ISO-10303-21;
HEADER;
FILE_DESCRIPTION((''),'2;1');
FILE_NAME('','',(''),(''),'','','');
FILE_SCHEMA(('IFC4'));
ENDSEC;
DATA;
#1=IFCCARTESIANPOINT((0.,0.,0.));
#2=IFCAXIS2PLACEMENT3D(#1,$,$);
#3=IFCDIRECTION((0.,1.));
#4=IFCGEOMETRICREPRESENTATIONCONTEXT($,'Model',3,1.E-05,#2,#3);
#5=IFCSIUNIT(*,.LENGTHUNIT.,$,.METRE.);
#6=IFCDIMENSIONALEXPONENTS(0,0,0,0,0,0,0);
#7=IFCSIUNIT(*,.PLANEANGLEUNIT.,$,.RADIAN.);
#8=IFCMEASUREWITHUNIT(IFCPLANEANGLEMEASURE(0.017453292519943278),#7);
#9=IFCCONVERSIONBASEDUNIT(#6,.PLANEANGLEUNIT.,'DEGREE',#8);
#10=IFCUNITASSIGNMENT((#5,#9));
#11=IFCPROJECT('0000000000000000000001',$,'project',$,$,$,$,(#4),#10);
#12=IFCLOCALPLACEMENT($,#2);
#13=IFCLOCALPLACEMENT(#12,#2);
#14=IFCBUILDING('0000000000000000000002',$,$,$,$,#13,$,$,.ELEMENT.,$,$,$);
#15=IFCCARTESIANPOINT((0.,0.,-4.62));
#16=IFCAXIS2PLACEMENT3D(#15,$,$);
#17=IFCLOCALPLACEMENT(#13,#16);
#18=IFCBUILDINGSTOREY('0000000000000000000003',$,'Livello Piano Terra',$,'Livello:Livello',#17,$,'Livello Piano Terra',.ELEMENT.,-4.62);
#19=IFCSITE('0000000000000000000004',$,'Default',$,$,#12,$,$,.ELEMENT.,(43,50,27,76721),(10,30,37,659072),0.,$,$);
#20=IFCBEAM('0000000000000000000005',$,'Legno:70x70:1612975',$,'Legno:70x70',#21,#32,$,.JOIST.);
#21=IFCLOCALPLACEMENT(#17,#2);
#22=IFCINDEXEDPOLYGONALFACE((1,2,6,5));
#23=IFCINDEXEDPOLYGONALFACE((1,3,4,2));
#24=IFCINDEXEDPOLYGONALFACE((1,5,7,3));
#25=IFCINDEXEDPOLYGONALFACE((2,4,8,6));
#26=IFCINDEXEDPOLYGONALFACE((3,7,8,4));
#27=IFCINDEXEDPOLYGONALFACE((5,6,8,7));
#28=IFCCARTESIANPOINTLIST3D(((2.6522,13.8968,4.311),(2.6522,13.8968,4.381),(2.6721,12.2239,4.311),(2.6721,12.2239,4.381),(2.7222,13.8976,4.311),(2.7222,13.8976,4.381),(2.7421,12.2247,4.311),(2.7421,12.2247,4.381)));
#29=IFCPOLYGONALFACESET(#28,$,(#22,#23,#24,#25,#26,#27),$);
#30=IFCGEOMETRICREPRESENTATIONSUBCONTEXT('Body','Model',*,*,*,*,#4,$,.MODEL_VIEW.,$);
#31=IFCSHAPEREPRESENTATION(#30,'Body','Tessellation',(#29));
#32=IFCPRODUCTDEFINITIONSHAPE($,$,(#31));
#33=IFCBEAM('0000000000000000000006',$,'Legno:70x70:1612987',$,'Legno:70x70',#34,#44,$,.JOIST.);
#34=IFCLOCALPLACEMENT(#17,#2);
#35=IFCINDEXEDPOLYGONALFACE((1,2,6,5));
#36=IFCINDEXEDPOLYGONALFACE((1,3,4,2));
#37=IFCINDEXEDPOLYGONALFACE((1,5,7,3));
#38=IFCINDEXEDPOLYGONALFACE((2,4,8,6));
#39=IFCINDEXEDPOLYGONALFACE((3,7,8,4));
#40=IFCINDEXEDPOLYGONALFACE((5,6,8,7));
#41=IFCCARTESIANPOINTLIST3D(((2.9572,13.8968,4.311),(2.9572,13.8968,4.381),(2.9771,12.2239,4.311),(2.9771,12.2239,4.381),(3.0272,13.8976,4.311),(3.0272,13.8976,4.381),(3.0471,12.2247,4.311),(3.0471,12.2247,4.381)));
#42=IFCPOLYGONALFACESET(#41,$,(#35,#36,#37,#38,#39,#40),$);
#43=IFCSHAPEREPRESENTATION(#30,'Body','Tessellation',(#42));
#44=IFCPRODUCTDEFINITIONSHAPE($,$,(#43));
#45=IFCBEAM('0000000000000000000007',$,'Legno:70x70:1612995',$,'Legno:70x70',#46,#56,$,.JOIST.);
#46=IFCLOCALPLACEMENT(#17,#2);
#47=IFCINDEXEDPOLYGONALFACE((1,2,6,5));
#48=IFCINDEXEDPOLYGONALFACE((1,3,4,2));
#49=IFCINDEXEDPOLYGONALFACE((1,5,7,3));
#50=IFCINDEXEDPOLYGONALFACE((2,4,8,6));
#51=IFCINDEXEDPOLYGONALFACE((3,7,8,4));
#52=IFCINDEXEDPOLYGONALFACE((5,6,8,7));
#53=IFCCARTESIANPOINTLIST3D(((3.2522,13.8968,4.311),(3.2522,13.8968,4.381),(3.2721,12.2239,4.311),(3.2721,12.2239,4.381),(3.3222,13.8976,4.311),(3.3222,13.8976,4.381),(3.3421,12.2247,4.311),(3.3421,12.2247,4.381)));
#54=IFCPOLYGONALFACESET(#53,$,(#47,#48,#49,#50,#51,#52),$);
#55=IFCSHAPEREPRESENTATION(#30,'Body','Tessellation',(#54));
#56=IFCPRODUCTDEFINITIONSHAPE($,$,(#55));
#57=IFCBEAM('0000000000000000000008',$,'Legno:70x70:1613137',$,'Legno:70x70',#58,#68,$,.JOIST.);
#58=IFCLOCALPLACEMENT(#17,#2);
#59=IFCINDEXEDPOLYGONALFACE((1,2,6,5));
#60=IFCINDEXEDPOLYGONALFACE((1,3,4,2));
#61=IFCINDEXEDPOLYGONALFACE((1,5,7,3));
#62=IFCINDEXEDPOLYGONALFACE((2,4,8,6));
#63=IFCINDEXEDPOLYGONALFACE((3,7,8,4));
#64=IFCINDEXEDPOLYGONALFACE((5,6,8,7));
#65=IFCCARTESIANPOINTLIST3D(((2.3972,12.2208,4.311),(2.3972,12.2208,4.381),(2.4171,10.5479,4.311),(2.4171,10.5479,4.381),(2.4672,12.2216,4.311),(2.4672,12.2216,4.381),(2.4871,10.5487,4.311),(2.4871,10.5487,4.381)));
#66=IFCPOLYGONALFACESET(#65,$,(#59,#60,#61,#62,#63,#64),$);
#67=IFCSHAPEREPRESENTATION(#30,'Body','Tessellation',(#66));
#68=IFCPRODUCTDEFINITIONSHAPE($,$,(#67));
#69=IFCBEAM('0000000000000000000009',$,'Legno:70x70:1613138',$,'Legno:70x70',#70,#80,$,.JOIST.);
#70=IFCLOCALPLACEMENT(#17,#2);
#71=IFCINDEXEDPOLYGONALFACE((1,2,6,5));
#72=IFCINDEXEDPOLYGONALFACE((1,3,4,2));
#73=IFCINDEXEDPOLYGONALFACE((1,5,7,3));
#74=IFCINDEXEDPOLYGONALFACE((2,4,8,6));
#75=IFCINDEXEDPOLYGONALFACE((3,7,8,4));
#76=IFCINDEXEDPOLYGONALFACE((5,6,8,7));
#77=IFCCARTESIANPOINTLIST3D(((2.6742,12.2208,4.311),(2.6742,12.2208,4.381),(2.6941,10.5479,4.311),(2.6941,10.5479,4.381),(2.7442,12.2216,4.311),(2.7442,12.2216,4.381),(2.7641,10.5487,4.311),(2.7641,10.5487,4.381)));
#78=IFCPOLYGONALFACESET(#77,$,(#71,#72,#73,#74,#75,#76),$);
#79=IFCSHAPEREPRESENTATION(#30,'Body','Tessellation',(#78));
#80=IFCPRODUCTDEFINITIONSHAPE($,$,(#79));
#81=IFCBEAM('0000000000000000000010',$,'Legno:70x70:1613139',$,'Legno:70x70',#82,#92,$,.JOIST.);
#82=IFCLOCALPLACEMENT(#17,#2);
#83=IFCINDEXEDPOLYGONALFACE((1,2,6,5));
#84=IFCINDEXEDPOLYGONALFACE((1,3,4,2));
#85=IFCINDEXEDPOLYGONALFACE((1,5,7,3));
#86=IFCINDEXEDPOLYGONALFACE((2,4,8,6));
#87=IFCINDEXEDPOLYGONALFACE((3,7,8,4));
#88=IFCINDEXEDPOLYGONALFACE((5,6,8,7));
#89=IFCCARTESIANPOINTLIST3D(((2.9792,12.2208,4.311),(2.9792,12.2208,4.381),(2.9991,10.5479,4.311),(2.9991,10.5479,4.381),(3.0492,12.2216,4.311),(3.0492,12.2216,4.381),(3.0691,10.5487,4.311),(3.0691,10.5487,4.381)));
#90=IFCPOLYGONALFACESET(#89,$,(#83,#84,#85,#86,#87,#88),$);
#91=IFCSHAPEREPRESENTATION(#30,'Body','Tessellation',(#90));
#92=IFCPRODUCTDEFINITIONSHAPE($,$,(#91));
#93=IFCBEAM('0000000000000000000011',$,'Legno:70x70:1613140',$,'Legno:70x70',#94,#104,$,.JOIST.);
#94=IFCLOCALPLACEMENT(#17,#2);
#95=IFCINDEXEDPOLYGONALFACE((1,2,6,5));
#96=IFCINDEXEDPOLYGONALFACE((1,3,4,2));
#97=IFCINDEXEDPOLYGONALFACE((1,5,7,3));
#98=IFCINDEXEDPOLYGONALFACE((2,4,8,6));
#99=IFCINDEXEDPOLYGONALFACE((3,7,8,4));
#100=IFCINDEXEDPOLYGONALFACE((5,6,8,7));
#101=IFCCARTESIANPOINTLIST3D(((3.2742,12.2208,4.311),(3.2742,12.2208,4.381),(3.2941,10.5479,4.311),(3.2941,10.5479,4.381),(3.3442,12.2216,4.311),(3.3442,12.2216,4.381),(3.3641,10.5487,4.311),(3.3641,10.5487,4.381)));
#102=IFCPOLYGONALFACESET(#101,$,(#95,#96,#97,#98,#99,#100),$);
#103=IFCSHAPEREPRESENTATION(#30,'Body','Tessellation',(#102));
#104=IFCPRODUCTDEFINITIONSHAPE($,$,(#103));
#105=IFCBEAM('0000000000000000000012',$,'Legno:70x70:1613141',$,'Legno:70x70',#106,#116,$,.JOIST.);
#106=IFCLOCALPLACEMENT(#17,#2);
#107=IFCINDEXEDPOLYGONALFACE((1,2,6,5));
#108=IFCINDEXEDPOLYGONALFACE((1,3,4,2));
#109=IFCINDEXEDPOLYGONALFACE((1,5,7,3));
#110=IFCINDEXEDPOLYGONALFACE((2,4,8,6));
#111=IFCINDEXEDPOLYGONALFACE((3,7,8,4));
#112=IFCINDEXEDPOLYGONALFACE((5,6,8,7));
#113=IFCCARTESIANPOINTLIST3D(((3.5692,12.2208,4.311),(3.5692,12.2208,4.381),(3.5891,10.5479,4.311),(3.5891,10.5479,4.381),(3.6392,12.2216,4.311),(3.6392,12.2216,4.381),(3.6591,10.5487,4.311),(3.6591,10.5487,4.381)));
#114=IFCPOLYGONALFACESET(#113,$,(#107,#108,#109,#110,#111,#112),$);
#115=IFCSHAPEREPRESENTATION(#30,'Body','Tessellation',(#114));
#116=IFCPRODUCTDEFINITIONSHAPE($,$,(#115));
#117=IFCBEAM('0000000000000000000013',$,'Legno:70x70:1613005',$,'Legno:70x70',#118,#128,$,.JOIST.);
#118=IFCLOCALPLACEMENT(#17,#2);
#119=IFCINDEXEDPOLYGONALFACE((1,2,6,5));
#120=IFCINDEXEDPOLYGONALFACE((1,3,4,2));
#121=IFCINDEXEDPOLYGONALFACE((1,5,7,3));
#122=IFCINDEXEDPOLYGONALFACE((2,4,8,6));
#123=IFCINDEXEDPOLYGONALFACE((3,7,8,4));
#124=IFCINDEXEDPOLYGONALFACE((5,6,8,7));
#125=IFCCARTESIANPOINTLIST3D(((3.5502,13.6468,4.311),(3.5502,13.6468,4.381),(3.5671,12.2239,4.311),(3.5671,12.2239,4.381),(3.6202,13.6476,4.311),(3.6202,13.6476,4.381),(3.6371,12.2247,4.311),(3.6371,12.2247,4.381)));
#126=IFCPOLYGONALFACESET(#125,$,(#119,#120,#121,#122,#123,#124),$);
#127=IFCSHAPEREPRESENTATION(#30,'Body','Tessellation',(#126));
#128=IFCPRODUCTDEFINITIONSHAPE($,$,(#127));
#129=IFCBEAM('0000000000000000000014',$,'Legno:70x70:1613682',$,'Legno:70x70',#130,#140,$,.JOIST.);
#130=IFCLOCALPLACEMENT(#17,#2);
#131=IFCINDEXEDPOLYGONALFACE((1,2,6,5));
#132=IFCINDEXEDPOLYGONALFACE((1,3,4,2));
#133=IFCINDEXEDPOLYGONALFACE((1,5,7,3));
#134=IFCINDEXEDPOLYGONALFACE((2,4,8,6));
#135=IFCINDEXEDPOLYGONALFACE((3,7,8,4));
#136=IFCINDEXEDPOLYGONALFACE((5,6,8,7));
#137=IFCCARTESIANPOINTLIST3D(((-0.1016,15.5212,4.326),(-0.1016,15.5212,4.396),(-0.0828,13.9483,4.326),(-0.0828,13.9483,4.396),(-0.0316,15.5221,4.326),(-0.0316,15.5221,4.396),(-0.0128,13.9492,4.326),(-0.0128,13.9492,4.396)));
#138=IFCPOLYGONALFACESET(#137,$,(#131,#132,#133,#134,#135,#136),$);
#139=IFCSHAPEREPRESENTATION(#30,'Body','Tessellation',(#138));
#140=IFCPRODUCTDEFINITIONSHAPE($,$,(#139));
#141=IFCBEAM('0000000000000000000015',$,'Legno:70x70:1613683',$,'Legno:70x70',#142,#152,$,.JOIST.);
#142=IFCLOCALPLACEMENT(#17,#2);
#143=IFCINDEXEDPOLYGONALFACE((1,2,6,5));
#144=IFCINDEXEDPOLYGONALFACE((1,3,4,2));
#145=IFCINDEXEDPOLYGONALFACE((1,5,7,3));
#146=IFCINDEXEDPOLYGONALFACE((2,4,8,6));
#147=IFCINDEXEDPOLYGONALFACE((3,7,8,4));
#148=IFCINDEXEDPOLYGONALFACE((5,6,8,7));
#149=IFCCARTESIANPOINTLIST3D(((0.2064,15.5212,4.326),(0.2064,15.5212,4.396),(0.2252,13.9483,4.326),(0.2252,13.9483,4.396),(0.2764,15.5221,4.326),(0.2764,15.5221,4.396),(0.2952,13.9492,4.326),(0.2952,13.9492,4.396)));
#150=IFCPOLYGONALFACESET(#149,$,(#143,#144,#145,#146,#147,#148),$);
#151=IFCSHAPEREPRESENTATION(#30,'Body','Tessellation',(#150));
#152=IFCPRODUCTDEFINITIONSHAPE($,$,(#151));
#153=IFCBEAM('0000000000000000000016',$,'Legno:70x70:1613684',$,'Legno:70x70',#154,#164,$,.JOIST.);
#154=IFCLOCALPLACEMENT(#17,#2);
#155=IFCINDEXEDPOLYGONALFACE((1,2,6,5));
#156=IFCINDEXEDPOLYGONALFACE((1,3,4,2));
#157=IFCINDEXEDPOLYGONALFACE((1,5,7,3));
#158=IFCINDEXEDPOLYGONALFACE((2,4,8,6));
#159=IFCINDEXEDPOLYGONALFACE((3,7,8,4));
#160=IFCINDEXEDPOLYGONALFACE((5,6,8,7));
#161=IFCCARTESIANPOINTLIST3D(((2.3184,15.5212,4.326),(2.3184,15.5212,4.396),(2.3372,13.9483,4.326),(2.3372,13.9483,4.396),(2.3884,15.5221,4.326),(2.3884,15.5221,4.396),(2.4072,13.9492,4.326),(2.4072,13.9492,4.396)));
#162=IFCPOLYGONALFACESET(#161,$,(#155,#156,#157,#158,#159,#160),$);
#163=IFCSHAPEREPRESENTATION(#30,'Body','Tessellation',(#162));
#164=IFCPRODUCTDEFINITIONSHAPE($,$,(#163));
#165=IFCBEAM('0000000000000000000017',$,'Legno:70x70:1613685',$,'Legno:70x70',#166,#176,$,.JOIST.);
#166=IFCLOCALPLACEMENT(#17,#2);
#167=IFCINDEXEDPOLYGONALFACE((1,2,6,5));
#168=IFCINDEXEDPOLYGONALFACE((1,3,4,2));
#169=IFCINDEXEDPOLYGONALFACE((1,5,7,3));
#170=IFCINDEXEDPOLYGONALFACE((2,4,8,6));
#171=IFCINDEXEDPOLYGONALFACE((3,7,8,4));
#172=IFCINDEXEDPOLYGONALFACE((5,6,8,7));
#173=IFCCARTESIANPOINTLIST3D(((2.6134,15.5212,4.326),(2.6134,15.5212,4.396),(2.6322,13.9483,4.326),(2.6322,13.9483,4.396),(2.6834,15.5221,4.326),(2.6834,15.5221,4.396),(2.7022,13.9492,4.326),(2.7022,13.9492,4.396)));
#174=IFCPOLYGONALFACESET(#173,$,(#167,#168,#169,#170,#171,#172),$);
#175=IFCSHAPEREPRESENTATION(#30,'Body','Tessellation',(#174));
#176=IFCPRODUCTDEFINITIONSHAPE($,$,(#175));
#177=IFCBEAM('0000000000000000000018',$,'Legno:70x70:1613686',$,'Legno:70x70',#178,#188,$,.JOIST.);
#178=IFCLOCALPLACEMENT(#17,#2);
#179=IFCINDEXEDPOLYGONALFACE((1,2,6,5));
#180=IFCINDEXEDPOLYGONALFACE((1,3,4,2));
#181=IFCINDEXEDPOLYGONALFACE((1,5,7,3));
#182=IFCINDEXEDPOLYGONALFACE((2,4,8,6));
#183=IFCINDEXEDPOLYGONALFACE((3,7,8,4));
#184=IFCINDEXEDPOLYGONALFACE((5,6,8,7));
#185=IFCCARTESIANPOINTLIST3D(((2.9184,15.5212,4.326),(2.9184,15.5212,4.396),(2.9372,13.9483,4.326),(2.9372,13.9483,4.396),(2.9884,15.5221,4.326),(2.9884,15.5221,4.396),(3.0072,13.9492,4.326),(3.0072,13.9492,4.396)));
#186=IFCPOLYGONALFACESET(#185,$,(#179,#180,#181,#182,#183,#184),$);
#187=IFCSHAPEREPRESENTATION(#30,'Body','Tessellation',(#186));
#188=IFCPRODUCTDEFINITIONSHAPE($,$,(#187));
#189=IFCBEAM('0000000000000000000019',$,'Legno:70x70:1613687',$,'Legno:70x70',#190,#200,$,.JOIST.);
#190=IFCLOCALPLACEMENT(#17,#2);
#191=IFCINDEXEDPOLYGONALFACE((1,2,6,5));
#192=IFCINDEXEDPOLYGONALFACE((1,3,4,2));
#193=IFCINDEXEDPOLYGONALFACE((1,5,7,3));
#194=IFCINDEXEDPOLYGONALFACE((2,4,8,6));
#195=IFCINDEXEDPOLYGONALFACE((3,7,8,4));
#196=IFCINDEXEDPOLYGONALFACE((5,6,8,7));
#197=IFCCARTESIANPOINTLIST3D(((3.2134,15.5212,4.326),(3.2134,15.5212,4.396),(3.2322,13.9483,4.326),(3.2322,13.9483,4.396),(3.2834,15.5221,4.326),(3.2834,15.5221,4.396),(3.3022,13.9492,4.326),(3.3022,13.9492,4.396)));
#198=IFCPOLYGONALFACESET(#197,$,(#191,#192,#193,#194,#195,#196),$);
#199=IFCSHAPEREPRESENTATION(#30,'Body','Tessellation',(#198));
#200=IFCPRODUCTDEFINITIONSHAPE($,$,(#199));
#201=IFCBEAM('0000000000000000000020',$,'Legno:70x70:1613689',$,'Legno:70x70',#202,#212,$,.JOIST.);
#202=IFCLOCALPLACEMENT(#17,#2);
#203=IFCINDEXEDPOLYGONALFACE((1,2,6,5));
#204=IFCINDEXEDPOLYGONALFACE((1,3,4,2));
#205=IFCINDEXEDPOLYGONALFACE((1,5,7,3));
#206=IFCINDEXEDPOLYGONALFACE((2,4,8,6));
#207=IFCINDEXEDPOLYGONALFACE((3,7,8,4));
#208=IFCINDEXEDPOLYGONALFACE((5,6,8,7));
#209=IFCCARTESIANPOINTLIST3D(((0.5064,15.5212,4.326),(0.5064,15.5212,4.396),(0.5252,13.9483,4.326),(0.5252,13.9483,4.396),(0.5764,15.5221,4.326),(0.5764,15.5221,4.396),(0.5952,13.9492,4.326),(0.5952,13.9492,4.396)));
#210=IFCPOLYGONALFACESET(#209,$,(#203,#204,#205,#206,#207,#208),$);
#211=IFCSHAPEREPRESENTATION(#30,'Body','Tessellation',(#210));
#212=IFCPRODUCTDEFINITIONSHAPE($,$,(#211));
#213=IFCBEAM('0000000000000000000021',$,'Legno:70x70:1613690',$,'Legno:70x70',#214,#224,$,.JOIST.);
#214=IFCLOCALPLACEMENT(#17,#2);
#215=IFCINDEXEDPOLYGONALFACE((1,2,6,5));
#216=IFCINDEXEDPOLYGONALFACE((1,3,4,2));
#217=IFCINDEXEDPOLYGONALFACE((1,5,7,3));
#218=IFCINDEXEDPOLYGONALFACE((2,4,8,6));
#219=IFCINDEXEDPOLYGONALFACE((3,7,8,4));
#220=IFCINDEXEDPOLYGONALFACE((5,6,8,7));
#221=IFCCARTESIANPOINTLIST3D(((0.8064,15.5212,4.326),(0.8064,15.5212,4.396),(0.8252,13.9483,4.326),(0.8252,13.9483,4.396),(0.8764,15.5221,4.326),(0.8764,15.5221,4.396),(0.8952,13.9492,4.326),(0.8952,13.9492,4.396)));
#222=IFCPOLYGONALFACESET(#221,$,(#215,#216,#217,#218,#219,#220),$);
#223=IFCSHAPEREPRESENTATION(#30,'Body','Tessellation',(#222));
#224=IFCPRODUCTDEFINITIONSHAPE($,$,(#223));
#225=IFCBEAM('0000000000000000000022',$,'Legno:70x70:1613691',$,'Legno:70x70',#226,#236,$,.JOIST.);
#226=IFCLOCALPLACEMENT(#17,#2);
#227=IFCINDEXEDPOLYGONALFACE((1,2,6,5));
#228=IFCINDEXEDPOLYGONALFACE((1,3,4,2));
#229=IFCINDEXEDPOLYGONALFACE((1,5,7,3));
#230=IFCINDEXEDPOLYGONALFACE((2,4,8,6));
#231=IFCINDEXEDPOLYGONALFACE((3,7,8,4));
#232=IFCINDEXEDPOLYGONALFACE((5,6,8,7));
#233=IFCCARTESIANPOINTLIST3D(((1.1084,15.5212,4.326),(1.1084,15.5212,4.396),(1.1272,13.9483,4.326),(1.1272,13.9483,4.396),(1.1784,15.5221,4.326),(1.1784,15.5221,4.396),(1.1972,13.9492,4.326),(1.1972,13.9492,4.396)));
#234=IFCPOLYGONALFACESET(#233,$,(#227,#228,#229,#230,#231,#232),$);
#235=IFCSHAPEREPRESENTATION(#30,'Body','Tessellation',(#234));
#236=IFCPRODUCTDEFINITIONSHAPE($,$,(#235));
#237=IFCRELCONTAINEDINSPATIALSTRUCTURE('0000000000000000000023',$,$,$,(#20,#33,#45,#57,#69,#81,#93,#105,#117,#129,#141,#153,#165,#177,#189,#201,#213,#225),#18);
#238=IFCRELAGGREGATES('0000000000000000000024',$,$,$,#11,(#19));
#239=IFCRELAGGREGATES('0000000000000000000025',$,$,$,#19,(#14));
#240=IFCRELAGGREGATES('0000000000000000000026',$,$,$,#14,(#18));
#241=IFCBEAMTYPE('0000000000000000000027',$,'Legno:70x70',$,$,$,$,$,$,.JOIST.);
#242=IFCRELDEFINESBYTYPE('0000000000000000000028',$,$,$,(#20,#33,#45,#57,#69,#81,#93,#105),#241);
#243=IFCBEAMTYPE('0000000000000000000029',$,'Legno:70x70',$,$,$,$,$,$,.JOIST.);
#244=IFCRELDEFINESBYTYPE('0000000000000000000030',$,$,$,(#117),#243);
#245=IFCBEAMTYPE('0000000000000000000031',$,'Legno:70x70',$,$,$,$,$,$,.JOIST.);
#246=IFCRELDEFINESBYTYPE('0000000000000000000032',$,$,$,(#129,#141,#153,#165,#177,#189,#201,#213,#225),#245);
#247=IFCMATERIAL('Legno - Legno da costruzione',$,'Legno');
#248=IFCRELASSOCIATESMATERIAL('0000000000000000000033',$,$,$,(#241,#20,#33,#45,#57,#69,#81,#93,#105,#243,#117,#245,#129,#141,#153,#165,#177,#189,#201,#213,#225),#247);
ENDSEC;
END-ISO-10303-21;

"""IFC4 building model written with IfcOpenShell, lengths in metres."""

from ifc_helpers import new_model, entity, si_unit, converted_unit, direction, frame, origin, place, context, subcontext, project, spatial, indexed_curve, outline, extrude, source, transform, mapped, material, type_object, type_shapes, element, save


model = new_model("IFC4")

# Units and contexts
model_context = context("Model", 3, precision=1e-05, world=origin(), true_north=direction((0.0, 1.0)))
body_context = subcontext(model_context, "Body", "Model", "MODEL_VIEW")
ifc_project = project(units=[si_unit("LENGTHUNIT", "METRE"), converted_unit("PLANEANGLEUNIT", "DEGREE", entity("IfcPlaneAngleMeasure", 0.017453292519943278), si_unit("PLANEANGLEUNIT", "RADIAN"), dimensions=[0, 0, 0, 0, 0, 0, 0])], contexts=[model_context])

# Site, building, storey
site_placement = place(None, origin())
site = spatial("IfcSite", under=ifc_project, at=site_placement, Name="Default", CompositionType="ELEMENT", RefLatitude=(43, 50, 27, 76721), RefLongitude=(10, 30, 37, 659072), RefElevation=0.0)
building_placement = place(site_placement, origin())
building = spatial("IfcBuilding", under=site, at=building_placement, CompositionType="ELEMENT")
storey_placement = place(building_placement, frame((0.0, 0.0, -4.62)))
storey = spatial("IfcBuildingStorey", under=building, at=storey_placement, Name="Livello Piano Terra", ObjectType="Livello:Livello", LongName="Livello Piano Terra", CompositionType="ELEMENT", Elevation=-4.62)

# Beams
ifc_material = material(Name="Legno - Legno da costruzione", Category="Legno")
beam_type_1 = type_object("IfcBeamType", Name="Legno:70x70", PredefinedType="JOIST", material=ifc_material)
shared_shape_1 = source(origin(), body_context, "Body", "SweptSolid", [
    extrude(outline(indexed_curve([(-0.8365, -0.035), (0.8365, -0.035), (0.8365, 0.035), (-0.8365, 0.035), (-0.8365, -0.035)], self_intersect=False)), frame((0.0, 0.0, -0.035), z_axis=(0.0, 0.0, 1.0), x_axis=(-1.0, 0.0, 0.0)), (0.0, 0.0, 1.0), 0.07),
])
type_shapes(beam_type_1, [shared_shape_1])
for number, where, z_axis, x_axis, name in (
    (1, (2.6972, 13.0608, 4.346), (0.0, 0.0, 1.0), (0.011914, -0.999929, 0.0), "Legno:70x70:1612975"),
    (2, (3.0022, 13.0608, 4.346), (0.0, 0.0, 1.0), (0.011914, -0.999929, 0.0), "Legno:70x70:1612987"),
    (3, (3.2972, 13.0608, 4.346), (0.0, 0.0, 1.0), (0.011914, -0.999929, 0.0), "Legno:70x70:1612995"),
    (4, (2.4422, 11.3848, 4.346), (0.0, 0.0, 1.0), (0.011914, -0.999929, 0.0), "Legno:70x70:1613137"),
    (5, (2.7192, 11.3848, 4.346), (0.0, 0.0, 1.0), (0.011914, -0.999929, 0.0), "Legno:70x70:1613138"),
    (6, (3.0242, 11.3848, 4.346), (0.0, 0.0, 1.0), (0.011914, -0.999929, 0.0), "Legno:70x70:1613139"),
    (7, (3.3192, 11.3848, 4.346), (0.0, 0.0, 1.0), (0.011914, -0.999929, 0.0), "Legno:70x70:1613140"),
    (8, (3.6142, 11.3848, 4.346), (0.0, 0.0, 1.0), (0.011914, -0.999929, 0.0), "Legno:70x70:1613141"),
):
    element("IfcBeam", number, at=place(storey_placement, frame(where, z_axis=z_axis, x_axis=x_axis)), inside=storey, type_object=beam_type_1, material=ifc_material, Name=name, ObjectType="Legno:70x70", PredefinedType="JOIST", context=body_context, shape_type="MappedRepresentation", body=[
        mapped(shared_shape_1, transform((0.0, 0.0, 0.0), scale=1.0)),
    ])
beam_type_2 = type_object("IfcBeamType", Name="Legno:70x70", PredefinedType="JOIST", material=ifc_material)
shared_shape_2 = source(origin(), body_context, "Body", "SweptSolid", [
    extrude(outline(indexed_curve([(-0.7115, -0.035), (0.7115, -0.035), (0.7115, 0.035), (-0.7115, 0.035), (-0.7115, -0.035)], self_intersect=False)), frame((0.125, 0.0, -0.035), z_axis=(0.0, 0.0, 1.0), x_axis=(-1.0, 0.0, 0.0)), (0.0, 0.0, 1.0), 0.07),
])
type_shapes(beam_type_2, [shared_shape_2])
beam_placement = place(storey_placement, frame((3.5922, 13.0608, 4.346), z_axis=(0.0, 0.0, 1.0), x_axis=(0.011914, -0.999929, 0.0)))
element("IfcBeam", 9, at=beam_placement, inside=storey, type_object=beam_type_2, material=ifc_material, Name="Legno:70x70:1613005", ObjectType="Legno:70x70", PredefinedType="JOIST", context=body_context, shape_type="MappedRepresentation", body=[
    mapped(shared_shape_2, transform((0.0, 0.0, 0.0), scale=1.0)),
])
beam_type_3 = type_object("IfcBeamType", Name="Legno:70x70", PredefinedType="JOIST", material=ifc_material)
shared_shape_3 = source(origin(), body_context, "Body", "SweptSolid", [
    extrude(outline(indexed_curve([(-0.7865, -0.035), (0.7865, -0.035), (0.7865, 0.035), (-0.7865, 0.035), (-0.7865, -0.035)], self_intersect=False)), frame((0.0, 0.0, -0.035), z_axis=(0.0, 0.0, 1.0), x_axis=(-1.0, 0.0, 0.0)), (0.0, 0.0, 1.0), 0.07),
])
type_shapes(beam_type_3, [shared_shape_3])
for number, where, z_axis, x_axis, name in (
    (10, (-0.0572, 14.7352, 4.361), (0.0, 0.0, 1.0), (0.011914, -0.999929, 0.0), "Legno:70x70:1613682"),
    (11, (0.2508, 14.7352, 4.361), (0.0, 0.0, 1.0), (0.011914, -0.999929, 0.0), "Legno:70x70:1613683"),
    (12, (2.3628, 14.7352, 4.361), (0.0, 0.0, 1.0), (0.011914, -0.999929, 0.0), "Legno:70x70:1613684"),
    (13, (2.6578, 14.7352, 4.361), (0.0, 0.0, 1.0), (0.011914, -0.999929, 0.0), "Legno:70x70:1613685"),
    (14, (2.9628, 14.7352, 4.361), (0.0, 0.0, 1.0), (0.011914, -0.999929, 0.0), "Legno:70x70:1613686"),
    (15, (3.2578, 14.7352, 4.361), (0.0, 0.0, 1.0), (0.011914, -0.999929, 0.0), "Legno:70x70:1613687"),
    (16, (0.5508, 14.7352, 4.361), (0.0, 0.0, 1.0), (0.011914, -0.999929, 0.0), "Legno:70x70:1613689"),
    (17, (0.8508, 14.7352, 4.361), (0.0, 0.0, 1.0), (0.011914, -0.999929, 0.0), "Legno:70x70:1613690"),
    (18, (1.1528, 14.7352, 4.361), (0.0, 0.0, 1.0), (0.011914, -0.999929, 0.0), "Legno:70x70:1613691"),
):
    element("IfcBeam", number, at=place(storey_placement, frame(where, z_axis=z_axis, x_axis=x_axis)), inside=storey, type_object=beam_type_3, material=ifc_material, Name=name, ObjectType="Legno:70x70", PredefinedType="JOIST", context=body_context, shape_type="MappedRepresentation", body=[
        mapped(shared_shape_3, transform((0.0, 0.0, 0.0), scale=1.0)),
    ])

save(model, "model.ifc")
